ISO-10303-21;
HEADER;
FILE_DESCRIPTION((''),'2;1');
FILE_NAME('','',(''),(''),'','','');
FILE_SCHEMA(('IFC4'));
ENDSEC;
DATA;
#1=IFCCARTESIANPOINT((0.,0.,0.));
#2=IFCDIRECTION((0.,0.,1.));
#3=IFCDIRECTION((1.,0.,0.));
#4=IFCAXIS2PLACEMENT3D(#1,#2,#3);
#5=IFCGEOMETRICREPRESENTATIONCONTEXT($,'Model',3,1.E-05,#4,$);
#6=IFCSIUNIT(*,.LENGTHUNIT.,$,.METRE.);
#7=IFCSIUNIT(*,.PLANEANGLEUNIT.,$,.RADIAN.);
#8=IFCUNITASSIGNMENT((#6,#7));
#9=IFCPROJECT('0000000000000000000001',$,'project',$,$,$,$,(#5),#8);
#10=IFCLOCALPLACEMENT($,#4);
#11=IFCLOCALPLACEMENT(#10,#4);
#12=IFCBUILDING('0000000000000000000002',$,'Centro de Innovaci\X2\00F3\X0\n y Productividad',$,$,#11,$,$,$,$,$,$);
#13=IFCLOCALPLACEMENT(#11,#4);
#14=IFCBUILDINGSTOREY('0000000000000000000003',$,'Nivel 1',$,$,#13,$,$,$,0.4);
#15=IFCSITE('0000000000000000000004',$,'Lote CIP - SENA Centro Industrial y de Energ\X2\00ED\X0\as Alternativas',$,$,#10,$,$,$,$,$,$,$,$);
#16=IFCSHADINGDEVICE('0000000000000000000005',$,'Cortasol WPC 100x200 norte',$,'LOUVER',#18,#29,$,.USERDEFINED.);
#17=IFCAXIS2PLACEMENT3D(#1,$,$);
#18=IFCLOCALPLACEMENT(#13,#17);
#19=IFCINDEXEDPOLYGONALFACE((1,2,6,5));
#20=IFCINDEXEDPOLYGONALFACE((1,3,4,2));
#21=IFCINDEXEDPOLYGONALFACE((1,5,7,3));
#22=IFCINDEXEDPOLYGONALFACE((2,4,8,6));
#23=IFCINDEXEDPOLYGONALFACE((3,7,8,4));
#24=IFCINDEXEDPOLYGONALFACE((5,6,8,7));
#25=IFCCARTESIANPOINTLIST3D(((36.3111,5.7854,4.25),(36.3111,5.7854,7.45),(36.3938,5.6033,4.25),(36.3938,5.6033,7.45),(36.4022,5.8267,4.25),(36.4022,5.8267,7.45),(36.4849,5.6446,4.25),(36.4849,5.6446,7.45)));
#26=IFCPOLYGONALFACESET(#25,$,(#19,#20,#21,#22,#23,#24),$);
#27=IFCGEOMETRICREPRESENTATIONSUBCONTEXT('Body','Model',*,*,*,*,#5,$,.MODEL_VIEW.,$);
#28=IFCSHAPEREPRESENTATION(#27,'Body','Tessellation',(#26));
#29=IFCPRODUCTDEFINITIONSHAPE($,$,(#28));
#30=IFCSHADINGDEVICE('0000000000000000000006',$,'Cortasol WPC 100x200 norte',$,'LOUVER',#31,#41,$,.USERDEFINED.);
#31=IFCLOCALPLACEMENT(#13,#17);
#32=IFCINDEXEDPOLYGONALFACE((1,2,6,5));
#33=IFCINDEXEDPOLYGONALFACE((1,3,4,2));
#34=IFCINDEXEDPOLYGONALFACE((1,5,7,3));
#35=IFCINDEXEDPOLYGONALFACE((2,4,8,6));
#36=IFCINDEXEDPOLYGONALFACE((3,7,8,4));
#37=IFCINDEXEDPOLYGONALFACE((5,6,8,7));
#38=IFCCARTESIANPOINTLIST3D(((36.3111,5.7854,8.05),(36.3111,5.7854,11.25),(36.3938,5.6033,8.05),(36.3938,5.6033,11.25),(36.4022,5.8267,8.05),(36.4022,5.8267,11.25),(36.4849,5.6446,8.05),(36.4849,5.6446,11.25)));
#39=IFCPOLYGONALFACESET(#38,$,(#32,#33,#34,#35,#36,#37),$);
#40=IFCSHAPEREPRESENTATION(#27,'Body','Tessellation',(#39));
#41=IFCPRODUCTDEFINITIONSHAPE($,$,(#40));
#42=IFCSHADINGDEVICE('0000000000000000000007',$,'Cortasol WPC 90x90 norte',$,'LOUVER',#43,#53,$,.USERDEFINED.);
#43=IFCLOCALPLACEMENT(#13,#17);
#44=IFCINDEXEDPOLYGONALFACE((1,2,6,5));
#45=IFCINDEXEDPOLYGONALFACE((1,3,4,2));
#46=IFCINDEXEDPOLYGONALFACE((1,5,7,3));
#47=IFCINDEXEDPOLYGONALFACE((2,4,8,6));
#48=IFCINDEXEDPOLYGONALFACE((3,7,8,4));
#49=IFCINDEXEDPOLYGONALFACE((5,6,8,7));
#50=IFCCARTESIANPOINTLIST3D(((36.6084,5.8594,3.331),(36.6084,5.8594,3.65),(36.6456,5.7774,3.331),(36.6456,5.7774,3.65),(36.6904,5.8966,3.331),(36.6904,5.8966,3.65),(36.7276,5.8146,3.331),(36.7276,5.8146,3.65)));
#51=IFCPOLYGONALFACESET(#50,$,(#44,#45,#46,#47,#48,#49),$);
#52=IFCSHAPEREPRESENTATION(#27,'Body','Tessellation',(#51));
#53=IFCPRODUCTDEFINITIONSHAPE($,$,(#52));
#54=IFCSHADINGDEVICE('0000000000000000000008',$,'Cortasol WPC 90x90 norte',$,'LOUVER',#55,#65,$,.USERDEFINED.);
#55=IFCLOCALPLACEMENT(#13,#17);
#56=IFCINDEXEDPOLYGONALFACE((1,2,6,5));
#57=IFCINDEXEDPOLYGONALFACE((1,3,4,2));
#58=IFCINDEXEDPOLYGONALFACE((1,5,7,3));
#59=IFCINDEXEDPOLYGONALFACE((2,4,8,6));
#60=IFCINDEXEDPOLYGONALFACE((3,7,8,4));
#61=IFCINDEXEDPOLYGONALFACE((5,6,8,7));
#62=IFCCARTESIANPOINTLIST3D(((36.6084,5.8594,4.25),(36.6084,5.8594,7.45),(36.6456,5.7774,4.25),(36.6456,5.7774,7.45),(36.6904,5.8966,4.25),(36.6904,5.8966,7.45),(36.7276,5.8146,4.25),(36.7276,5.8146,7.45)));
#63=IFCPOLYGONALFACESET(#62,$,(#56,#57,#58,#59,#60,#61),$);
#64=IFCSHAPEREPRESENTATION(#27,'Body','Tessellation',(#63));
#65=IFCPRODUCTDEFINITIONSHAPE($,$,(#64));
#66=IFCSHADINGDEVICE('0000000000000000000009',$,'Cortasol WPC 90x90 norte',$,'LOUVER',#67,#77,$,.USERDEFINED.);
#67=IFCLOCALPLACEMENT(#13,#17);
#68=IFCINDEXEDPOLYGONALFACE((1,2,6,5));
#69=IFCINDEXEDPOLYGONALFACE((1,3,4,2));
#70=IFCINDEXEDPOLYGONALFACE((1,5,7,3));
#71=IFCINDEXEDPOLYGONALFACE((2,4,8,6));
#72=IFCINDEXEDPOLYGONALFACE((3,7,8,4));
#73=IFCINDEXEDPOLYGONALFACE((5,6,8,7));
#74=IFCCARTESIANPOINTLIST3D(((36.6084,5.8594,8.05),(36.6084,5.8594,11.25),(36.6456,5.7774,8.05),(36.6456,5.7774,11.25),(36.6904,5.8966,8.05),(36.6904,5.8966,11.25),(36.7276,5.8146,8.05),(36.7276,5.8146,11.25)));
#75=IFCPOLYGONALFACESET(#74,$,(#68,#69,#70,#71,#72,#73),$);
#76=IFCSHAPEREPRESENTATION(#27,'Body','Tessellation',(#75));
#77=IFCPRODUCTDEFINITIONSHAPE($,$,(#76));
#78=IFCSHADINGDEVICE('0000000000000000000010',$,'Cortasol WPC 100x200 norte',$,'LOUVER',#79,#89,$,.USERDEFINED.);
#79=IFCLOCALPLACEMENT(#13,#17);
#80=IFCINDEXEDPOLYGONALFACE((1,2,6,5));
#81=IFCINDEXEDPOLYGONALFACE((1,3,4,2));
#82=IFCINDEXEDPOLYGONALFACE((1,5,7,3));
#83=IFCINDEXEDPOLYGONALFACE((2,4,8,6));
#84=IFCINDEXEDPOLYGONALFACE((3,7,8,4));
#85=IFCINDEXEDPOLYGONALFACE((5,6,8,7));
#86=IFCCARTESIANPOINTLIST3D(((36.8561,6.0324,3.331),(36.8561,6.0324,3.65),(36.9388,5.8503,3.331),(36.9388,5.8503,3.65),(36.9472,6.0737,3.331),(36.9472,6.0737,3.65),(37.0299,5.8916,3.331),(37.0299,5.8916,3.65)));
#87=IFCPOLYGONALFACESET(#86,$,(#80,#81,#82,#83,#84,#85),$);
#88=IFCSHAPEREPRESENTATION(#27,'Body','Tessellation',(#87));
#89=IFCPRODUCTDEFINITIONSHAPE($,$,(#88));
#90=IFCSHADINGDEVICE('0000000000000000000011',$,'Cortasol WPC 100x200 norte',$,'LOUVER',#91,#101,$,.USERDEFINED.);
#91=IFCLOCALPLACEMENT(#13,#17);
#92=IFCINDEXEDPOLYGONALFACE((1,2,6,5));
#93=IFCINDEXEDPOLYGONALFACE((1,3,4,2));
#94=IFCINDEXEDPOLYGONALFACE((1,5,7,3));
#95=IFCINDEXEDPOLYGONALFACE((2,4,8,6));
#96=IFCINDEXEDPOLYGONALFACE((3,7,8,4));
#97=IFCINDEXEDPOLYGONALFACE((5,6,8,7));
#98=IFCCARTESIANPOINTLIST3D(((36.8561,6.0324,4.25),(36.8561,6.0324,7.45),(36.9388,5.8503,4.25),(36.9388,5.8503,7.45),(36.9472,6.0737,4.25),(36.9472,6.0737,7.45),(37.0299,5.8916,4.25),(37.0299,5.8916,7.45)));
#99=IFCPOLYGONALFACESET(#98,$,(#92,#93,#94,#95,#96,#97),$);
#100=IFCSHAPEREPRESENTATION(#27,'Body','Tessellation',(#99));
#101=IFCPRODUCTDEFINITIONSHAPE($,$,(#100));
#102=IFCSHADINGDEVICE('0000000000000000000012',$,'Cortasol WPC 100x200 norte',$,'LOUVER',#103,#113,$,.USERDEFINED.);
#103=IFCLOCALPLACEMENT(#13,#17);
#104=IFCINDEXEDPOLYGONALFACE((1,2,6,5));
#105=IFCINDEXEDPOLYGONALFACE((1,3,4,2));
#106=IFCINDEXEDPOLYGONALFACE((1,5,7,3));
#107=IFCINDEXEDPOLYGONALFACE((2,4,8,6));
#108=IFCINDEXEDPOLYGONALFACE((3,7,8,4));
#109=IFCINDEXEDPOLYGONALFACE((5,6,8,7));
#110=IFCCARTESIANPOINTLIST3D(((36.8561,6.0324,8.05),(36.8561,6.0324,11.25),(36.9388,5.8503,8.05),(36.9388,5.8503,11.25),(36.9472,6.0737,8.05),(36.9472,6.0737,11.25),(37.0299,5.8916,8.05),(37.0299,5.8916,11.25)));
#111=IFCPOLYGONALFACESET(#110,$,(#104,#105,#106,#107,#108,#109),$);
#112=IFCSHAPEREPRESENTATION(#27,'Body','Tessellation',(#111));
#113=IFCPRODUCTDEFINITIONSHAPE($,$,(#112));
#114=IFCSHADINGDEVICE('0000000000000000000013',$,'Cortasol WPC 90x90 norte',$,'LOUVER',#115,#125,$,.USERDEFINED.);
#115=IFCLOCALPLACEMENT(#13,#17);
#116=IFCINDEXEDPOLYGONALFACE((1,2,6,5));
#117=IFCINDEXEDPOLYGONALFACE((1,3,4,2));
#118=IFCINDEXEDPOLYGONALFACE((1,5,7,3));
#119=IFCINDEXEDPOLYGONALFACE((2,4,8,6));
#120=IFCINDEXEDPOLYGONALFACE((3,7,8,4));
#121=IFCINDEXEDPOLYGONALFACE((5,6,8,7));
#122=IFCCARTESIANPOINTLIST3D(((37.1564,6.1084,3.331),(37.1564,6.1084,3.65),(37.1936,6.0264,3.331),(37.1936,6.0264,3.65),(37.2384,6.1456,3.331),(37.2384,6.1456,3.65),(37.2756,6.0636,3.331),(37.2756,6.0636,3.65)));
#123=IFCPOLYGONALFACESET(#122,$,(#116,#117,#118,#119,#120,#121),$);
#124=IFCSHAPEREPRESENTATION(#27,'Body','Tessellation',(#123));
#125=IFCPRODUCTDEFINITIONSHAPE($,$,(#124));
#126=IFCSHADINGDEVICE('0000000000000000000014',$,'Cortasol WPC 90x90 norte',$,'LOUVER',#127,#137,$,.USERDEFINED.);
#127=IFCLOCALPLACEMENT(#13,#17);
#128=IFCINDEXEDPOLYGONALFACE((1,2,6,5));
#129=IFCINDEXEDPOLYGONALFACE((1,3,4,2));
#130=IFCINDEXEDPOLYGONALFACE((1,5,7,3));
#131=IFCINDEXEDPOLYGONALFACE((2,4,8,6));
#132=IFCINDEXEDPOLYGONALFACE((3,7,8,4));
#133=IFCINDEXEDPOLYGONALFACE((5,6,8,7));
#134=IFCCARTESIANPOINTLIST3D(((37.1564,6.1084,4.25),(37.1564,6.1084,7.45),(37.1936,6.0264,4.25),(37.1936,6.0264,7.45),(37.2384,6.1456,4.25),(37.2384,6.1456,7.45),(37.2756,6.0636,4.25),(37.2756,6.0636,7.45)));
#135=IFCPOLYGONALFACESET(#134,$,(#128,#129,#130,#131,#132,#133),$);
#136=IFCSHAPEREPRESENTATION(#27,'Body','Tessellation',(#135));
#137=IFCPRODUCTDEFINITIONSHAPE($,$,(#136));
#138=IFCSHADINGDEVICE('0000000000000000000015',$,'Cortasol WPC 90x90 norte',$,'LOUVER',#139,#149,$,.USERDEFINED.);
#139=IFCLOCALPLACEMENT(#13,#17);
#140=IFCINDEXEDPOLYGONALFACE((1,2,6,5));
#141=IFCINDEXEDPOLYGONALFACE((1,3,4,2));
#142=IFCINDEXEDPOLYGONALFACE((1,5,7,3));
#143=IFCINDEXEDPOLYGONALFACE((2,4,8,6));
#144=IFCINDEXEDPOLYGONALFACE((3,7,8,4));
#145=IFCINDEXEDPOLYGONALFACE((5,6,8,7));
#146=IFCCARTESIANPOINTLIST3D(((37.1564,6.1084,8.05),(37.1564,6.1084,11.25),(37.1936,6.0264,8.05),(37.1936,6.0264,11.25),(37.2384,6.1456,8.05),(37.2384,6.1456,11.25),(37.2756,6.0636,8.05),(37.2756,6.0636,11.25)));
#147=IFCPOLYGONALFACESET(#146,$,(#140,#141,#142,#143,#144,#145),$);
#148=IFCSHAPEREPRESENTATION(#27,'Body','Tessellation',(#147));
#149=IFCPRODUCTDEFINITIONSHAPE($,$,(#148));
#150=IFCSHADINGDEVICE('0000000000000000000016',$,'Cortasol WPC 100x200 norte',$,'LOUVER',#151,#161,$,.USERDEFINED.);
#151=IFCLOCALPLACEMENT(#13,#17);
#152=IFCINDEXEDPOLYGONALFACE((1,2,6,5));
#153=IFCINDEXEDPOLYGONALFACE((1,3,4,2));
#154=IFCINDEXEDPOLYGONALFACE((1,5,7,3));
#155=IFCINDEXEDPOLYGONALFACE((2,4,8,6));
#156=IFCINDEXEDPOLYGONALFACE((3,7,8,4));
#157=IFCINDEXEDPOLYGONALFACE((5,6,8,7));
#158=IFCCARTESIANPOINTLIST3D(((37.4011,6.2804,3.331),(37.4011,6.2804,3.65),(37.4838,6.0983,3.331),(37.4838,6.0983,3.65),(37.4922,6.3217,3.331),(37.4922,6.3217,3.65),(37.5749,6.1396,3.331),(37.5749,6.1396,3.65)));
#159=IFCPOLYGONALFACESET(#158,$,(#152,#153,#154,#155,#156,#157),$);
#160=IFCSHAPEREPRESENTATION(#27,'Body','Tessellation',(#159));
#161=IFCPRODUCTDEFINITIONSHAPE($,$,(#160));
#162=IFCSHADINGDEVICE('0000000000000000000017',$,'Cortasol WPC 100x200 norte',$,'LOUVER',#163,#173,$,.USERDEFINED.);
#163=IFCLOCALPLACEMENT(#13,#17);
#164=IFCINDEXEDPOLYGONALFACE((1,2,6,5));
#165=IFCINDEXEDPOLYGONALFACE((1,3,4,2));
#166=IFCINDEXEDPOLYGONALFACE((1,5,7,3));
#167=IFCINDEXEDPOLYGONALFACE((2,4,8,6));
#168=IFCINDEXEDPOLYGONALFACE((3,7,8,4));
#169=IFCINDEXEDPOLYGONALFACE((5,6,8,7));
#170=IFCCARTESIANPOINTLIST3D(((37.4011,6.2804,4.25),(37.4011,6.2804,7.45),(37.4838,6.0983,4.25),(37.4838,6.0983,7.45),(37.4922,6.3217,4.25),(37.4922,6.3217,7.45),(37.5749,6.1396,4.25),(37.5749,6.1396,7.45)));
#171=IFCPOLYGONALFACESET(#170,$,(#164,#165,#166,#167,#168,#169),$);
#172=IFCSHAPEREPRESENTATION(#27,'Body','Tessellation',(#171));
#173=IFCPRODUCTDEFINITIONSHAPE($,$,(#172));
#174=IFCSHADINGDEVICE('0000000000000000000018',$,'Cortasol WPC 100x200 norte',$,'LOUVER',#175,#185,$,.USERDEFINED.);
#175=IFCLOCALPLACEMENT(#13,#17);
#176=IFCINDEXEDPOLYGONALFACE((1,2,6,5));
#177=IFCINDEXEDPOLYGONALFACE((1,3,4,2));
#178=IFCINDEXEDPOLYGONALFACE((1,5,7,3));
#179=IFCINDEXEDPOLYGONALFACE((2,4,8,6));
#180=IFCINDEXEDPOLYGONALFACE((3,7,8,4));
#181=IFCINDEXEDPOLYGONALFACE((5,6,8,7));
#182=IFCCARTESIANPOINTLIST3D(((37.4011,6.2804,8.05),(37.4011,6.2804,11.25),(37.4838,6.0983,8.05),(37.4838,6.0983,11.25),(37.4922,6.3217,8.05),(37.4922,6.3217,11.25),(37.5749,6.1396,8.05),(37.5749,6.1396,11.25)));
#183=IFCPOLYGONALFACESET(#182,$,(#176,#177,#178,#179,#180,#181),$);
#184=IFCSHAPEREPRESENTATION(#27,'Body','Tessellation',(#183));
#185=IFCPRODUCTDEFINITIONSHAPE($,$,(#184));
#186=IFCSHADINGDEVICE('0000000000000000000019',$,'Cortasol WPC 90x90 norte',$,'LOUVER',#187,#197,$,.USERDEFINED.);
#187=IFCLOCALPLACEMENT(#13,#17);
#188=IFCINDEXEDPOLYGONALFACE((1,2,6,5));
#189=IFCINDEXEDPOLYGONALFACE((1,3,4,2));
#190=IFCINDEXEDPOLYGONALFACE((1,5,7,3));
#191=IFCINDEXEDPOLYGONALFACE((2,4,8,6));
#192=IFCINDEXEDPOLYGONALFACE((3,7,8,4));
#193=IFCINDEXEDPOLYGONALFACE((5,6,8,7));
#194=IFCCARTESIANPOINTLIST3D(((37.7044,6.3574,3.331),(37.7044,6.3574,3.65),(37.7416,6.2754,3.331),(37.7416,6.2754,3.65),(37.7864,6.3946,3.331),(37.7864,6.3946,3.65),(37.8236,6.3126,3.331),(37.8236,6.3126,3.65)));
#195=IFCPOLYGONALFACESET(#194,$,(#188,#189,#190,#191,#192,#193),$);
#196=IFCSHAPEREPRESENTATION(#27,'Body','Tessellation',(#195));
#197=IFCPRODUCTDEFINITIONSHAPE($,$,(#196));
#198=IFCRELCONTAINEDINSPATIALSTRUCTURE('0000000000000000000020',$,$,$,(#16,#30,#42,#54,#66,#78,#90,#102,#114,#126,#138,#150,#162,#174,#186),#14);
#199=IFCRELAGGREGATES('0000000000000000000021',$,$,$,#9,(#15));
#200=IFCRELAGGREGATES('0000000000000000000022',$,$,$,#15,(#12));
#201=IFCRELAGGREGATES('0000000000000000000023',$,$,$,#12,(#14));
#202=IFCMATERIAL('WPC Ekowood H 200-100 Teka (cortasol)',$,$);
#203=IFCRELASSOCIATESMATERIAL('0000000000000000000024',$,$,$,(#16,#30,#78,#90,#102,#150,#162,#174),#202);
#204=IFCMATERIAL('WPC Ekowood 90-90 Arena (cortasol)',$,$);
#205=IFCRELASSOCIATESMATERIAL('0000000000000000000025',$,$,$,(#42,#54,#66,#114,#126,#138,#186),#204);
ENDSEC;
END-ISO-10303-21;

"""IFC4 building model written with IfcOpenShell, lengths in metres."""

from ifc_helpers import new_model, si_unit, frame, origin_with_axes, place, context, subcontext, project, spatial, polyline, outline, extrude, material, element, save


model = new_model("IFC4")

# Units and contexts
model_context = context("Model", 3, precision=1e-05, world=origin_with_axes())
body_context = subcontext(model_context, "Body", "Model", "MODEL_VIEW")
ifc_project = project(units=[si_unit("LENGTHUNIT", "METRE"), si_unit("PLANEANGLEUNIT", "RADIAN")], contexts=[model_context])

# Site, building, storey
site_placement = place(None, origin_with_axes())
site = spatial("IfcSite", under=ifc_project, at=site_placement, Name="Lote CIP - SENA Centro Industrial y de Energías Alternativas")
building_placement = place(site_placement, origin_with_axes())
building = spatial("IfcBuilding", under=site, at=building_placement, Name="Centro de Innovación y Productividad")
storey_placement = place(building_placement, origin_with_axes())
storey = spatial("IfcBuildingStorey", under=building, at=storey_placement, Name="Nivel 1", Elevation=0.4)

# Shading devices
ifc_material_1 = material(Name="WPC Ekowood H 200-100 Teka (cortasol)")
shading_device_1_placement = place(storey_placement, origin_with_axes())
element("IfcShadingDevice", 1, at=shading_device_1_placement, inside=storey, material=ifc_material_1, Name="Cortasol WPC 100x200 norte", ObjectType="LOUVER", PredefinedType="USERDEFINED", context=body_context, shape_type="SweptSolid", body=[
    extrude(outline(polyline([(36.3938, 5.6033), (36.3111, 5.7854), (36.4022, 5.8267), (36.4849, 5.6446), (36.3938, 5.6033)])), frame((0.0, 0.0, 4.25)), (0.0, 0.0, 1.0), 3.2),
])
shading_device_2_placement = place(storey_placement, origin_with_axes())
element("IfcShadingDevice", 2, at=shading_device_2_placement, inside=storey, material=ifc_material_1, Name="Cortasol WPC 100x200 norte", ObjectType="LOUVER", PredefinedType="USERDEFINED", context=body_context, shape_type="SweptSolid", body=[
    extrude(outline(polyline([(36.3938, 5.6033), (36.3111, 5.7854), (36.4022, 5.8267), (36.4849, 5.6446), (36.3938, 5.6033)])), frame((0.0, 0.0, 8.05)), (0.0, 0.0, 1.0), 3.2),
])
ifc_material_2 = material(Name="WPC Ekowood 90-90 Arena (cortasol)")
shading_device_3_placement = place(storey_placement, origin_with_axes())
element("IfcShadingDevice", 3, at=shading_device_3_placement, inside=storey, material=ifc_material_2, Name="Cortasol WPC 90x90 norte", ObjectType="LOUVER", PredefinedType="USERDEFINED", context=body_context, shape_type="SweptSolid", body=[
    extrude(outline(polyline([(36.6456, 5.7774), (36.6084, 5.8594), (36.6904, 5.8966), (36.7276, 5.8146), (36.6456, 5.7774)])), frame((0.0, 0.0, 3.331)), (0.0, 0.0, 1.0), 0.319),
])
shading_device_4_placement = place(storey_placement, origin_with_axes())
element("IfcShadingDevice", 4, at=shading_device_4_placement, inside=storey, material=ifc_material_2, Name="Cortasol WPC 90x90 norte", ObjectType="LOUVER", PredefinedType="USERDEFINED", context=body_context, shape_type="SweptSolid", body=[
    extrude(outline(polyline([(36.6456, 5.7774), (36.6084, 5.8594), (36.6904, 5.8966), (36.7276, 5.8146), (36.6456, 5.7774)])), frame((0.0, 0.0, 4.25)), (0.0, 0.0, 1.0), 3.2),
])
shading_device_5_placement = place(storey_placement, origin_with_axes())
element("IfcShadingDevice", 5, at=shading_device_5_placement, inside=storey, material=ifc_material_2, Name="Cortasol WPC 90x90 norte", ObjectType="LOUVER", PredefinedType="USERDEFINED", context=body_context, shape_type="SweptSolid", body=[
    extrude(outline(polyline([(36.6456, 5.7774), (36.6084, 5.8594), (36.6904, 5.8966), (36.7276, 5.8146), (36.6456, 5.7774)])), frame((0.0, 0.0, 8.05)), (0.0, 0.0, 1.0), 3.2),
])
shading_device_6_placement = place(storey_placement, origin_with_axes())
element("IfcShadingDevice", 6, at=shading_device_6_placement, inside=storey, material=ifc_material_1, Name="Cortasol WPC 100x200 norte", ObjectType="LOUVER", PredefinedType="USERDEFINED", context=body_context, shape_type="SweptSolid", body=[
    extrude(outline(polyline([(36.9388, 5.8503), (36.8561, 6.0324), (36.9472, 6.0737), (37.0299, 5.8916), (36.9388, 5.8503)])), frame((0.0, 0.0, 3.331)), (0.0, 0.0, 1.0), 0.319),
])
shading_device_7_placement = place(storey_placement, origin_with_axes())
element("IfcShadingDevice", 7, at=shading_device_7_placement, inside=storey, material=ifc_material_1, Name="Cortasol WPC 100x200 norte", ObjectType="LOUVER", PredefinedType="USERDEFINED", context=body_context, shape_type="SweptSolid", body=[
    extrude(outline(polyline([(36.9388, 5.8503), (36.8561, 6.0324), (36.9472, 6.0737), (37.0299, 5.8916), (36.9388, 5.8503)])), frame((0.0, 0.0, 4.25)), (0.0, 0.0, 1.0), 3.2),
])
shading_device_8_placement = place(storey_placement, origin_with_axes())
element("IfcShadingDevice", 8, at=shading_device_8_placement, inside=storey, material=ifc_material_1, Name="Cortasol WPC 100x200 norte", ObjectType="LOUVER", PredefinedType="USERDEFINED", context=body_context, shape_type="SweptSolid", body=[
    extrude(outline(polyline([(36.9388, 5.8503), (36.8561, 6.0324), (36.9472, 6.0737), (37.0299, 5.8916), (36.9388, 5.8503)])), frame((0.0, 0.0, 8.05)), (0.0, 0.0, 1.0), 3.2),
])
shading_device_9_placement = place(storey_placement, origin_with_axes())
element("IfcShadingDevice", 9, at=shading_device_9_placement, inside=storey, material=ifc_material_2, Name="Cortasol WPC 90x90 norte", ObjectType="LOUVER", PredefinedType="USERDEFINED", context=body_context, shape_type="SweptSolid", body=[
    extrude(outline(polyline([(37.1936, 6.0264), (37.1564, 6.1084), (37.2384, 6.1456), (37.2756, 6.0636), (37.1936, 6.0264)])), frame((0.0, 0.0, 3.331)), (0.0, 0.0, 1.0), 0.319),
])
shading_device_10_placement = place(storey_placement, origin_with_axes())
element("IfcShadingDevice", 10, at=shading_device_10_placement, inside=storey, material=ifc_material_2, Name="Cortasol WPC 90x90 norte", ObjectType="LOUVER", PredefinedType="USERDEFINED", context=body_context, shape_type="SweptSolid", body=[
    extrude(outline(polyline([(37.1936, 6.0264), (37.1564, 6.1084), (37.2384, 6.1456), (37.2756, 6.0636), (37.1936, 6.0264)])), frame((0.0, 0.0, 4.25)), (0.0, 0.0, 1.0), 3.2),
])
shading_device_11_placement = place(storey_placement, origin_with_axes())
element("IfcShadingDevice", 11, at=shading_device_11_placement, inside=storey, material=ifc_material_2, Name="Cortasol WPC 90x90 norte", ObjectType="LOUVER", PredefinedType="USERDEFINED", context=body_context, shape_type="SweptSolid", body=[
    extrude(outline(polyline([(37.1936, 6.0264), (37.1564, 6.1084), (37.2384, 6.1456), (37.2756, 6.0636), (37.1936, 6.0264)])), frame((0.0, 0.0, 8.05)), (0.0, 0.0, 1.0), 3.2),
])
shading_device_12_placement = place(storey_placement, origin_with_axes())
element("IfcShadingDevice", 12, at=shading_device_12_placement, inside=storey, material=ifc_material_1, Name="Cortasol WPC 100x200 norte", ObjectType="LOUVER", PredefinedType="USERDEFINED", context=body_context, shape_type="SweptSolid", body=[
    extrude(outline(polyline([(37.4838, 6.0983), (37.4011, 6.2804), (37.4922, 6.3217), (37.5749, 6.1396), (37.4838, 6.0983)])), frame((0.0, 0.0, 3.331)), (0.0, 0.0, 1.0), 0.319),
])
shading_device_13_placement = place(storey_placement, origin_with_axes())
element("IfcShadingDevice", 13, at=shading_device_13_placement, inside=storey, material=ifc_material_1, Name="Cortasol WPC 100x200 norte", ObjectType="LOUVER", PredefinedType="USERDEFINED", context=body_context, shape_type="SweptSolid", body=[
    extrude(outline(polyline([(37.4838, 6.0983), (37.4011, 6.2804), (37.4922, 6.3217), (37.5749, 6.1396), (37.4838, 6.0983)])), frame((0.0, 0.0, 4.25)), (0.0, 0.0, 1.0), 3.2),
])
shading_device_14_placement = place(storey_placement, origin_with_axes())
element("IfcShadingDevice", 14, at=shading_device_14_placement, inside=storey, material=ifc_material_1, Name="Cortasol WPC 100x200 norte", ObjectType="LOUVER", PredefinedType="USERDEFINED", context=body_context, shape_type="SweptSolid", body=[
    extrude(outline(polyline([(37.4838, 6.0983), (37.4011, 6.2804), (37.4922, 6.3217), (37.5749, 6.1396), (37.4838, 6.0983)])), frame((0.0, 0.0, 8.05)), (0.0, 0.0, 1.0), 3.2),
])
shading_device_15_placement = place(storey_placement, origin_with_axes())
element("IfcShadingDevice", 15, at=shading_device_15_placement, inside=storey, material=ifc_material_2, Name="Cortasol WPC 90x90 norte", ObjectType="LOUVER", PredefinedType="USERDEFINED", context=body_context, shape_type="SweptSolid", body=[
    extrude(outline(polyline([(37.7416, 6.2754), (37.7044, 6.3574), (37.7864, 6.3946), (37.8236, 6.3126), (37.7416, 6.2754)])), frame((0.0, 0.0, 3.331)), (0.0, 0.0, 1.0), 0.319),
])

save(model, "model.ifc")
